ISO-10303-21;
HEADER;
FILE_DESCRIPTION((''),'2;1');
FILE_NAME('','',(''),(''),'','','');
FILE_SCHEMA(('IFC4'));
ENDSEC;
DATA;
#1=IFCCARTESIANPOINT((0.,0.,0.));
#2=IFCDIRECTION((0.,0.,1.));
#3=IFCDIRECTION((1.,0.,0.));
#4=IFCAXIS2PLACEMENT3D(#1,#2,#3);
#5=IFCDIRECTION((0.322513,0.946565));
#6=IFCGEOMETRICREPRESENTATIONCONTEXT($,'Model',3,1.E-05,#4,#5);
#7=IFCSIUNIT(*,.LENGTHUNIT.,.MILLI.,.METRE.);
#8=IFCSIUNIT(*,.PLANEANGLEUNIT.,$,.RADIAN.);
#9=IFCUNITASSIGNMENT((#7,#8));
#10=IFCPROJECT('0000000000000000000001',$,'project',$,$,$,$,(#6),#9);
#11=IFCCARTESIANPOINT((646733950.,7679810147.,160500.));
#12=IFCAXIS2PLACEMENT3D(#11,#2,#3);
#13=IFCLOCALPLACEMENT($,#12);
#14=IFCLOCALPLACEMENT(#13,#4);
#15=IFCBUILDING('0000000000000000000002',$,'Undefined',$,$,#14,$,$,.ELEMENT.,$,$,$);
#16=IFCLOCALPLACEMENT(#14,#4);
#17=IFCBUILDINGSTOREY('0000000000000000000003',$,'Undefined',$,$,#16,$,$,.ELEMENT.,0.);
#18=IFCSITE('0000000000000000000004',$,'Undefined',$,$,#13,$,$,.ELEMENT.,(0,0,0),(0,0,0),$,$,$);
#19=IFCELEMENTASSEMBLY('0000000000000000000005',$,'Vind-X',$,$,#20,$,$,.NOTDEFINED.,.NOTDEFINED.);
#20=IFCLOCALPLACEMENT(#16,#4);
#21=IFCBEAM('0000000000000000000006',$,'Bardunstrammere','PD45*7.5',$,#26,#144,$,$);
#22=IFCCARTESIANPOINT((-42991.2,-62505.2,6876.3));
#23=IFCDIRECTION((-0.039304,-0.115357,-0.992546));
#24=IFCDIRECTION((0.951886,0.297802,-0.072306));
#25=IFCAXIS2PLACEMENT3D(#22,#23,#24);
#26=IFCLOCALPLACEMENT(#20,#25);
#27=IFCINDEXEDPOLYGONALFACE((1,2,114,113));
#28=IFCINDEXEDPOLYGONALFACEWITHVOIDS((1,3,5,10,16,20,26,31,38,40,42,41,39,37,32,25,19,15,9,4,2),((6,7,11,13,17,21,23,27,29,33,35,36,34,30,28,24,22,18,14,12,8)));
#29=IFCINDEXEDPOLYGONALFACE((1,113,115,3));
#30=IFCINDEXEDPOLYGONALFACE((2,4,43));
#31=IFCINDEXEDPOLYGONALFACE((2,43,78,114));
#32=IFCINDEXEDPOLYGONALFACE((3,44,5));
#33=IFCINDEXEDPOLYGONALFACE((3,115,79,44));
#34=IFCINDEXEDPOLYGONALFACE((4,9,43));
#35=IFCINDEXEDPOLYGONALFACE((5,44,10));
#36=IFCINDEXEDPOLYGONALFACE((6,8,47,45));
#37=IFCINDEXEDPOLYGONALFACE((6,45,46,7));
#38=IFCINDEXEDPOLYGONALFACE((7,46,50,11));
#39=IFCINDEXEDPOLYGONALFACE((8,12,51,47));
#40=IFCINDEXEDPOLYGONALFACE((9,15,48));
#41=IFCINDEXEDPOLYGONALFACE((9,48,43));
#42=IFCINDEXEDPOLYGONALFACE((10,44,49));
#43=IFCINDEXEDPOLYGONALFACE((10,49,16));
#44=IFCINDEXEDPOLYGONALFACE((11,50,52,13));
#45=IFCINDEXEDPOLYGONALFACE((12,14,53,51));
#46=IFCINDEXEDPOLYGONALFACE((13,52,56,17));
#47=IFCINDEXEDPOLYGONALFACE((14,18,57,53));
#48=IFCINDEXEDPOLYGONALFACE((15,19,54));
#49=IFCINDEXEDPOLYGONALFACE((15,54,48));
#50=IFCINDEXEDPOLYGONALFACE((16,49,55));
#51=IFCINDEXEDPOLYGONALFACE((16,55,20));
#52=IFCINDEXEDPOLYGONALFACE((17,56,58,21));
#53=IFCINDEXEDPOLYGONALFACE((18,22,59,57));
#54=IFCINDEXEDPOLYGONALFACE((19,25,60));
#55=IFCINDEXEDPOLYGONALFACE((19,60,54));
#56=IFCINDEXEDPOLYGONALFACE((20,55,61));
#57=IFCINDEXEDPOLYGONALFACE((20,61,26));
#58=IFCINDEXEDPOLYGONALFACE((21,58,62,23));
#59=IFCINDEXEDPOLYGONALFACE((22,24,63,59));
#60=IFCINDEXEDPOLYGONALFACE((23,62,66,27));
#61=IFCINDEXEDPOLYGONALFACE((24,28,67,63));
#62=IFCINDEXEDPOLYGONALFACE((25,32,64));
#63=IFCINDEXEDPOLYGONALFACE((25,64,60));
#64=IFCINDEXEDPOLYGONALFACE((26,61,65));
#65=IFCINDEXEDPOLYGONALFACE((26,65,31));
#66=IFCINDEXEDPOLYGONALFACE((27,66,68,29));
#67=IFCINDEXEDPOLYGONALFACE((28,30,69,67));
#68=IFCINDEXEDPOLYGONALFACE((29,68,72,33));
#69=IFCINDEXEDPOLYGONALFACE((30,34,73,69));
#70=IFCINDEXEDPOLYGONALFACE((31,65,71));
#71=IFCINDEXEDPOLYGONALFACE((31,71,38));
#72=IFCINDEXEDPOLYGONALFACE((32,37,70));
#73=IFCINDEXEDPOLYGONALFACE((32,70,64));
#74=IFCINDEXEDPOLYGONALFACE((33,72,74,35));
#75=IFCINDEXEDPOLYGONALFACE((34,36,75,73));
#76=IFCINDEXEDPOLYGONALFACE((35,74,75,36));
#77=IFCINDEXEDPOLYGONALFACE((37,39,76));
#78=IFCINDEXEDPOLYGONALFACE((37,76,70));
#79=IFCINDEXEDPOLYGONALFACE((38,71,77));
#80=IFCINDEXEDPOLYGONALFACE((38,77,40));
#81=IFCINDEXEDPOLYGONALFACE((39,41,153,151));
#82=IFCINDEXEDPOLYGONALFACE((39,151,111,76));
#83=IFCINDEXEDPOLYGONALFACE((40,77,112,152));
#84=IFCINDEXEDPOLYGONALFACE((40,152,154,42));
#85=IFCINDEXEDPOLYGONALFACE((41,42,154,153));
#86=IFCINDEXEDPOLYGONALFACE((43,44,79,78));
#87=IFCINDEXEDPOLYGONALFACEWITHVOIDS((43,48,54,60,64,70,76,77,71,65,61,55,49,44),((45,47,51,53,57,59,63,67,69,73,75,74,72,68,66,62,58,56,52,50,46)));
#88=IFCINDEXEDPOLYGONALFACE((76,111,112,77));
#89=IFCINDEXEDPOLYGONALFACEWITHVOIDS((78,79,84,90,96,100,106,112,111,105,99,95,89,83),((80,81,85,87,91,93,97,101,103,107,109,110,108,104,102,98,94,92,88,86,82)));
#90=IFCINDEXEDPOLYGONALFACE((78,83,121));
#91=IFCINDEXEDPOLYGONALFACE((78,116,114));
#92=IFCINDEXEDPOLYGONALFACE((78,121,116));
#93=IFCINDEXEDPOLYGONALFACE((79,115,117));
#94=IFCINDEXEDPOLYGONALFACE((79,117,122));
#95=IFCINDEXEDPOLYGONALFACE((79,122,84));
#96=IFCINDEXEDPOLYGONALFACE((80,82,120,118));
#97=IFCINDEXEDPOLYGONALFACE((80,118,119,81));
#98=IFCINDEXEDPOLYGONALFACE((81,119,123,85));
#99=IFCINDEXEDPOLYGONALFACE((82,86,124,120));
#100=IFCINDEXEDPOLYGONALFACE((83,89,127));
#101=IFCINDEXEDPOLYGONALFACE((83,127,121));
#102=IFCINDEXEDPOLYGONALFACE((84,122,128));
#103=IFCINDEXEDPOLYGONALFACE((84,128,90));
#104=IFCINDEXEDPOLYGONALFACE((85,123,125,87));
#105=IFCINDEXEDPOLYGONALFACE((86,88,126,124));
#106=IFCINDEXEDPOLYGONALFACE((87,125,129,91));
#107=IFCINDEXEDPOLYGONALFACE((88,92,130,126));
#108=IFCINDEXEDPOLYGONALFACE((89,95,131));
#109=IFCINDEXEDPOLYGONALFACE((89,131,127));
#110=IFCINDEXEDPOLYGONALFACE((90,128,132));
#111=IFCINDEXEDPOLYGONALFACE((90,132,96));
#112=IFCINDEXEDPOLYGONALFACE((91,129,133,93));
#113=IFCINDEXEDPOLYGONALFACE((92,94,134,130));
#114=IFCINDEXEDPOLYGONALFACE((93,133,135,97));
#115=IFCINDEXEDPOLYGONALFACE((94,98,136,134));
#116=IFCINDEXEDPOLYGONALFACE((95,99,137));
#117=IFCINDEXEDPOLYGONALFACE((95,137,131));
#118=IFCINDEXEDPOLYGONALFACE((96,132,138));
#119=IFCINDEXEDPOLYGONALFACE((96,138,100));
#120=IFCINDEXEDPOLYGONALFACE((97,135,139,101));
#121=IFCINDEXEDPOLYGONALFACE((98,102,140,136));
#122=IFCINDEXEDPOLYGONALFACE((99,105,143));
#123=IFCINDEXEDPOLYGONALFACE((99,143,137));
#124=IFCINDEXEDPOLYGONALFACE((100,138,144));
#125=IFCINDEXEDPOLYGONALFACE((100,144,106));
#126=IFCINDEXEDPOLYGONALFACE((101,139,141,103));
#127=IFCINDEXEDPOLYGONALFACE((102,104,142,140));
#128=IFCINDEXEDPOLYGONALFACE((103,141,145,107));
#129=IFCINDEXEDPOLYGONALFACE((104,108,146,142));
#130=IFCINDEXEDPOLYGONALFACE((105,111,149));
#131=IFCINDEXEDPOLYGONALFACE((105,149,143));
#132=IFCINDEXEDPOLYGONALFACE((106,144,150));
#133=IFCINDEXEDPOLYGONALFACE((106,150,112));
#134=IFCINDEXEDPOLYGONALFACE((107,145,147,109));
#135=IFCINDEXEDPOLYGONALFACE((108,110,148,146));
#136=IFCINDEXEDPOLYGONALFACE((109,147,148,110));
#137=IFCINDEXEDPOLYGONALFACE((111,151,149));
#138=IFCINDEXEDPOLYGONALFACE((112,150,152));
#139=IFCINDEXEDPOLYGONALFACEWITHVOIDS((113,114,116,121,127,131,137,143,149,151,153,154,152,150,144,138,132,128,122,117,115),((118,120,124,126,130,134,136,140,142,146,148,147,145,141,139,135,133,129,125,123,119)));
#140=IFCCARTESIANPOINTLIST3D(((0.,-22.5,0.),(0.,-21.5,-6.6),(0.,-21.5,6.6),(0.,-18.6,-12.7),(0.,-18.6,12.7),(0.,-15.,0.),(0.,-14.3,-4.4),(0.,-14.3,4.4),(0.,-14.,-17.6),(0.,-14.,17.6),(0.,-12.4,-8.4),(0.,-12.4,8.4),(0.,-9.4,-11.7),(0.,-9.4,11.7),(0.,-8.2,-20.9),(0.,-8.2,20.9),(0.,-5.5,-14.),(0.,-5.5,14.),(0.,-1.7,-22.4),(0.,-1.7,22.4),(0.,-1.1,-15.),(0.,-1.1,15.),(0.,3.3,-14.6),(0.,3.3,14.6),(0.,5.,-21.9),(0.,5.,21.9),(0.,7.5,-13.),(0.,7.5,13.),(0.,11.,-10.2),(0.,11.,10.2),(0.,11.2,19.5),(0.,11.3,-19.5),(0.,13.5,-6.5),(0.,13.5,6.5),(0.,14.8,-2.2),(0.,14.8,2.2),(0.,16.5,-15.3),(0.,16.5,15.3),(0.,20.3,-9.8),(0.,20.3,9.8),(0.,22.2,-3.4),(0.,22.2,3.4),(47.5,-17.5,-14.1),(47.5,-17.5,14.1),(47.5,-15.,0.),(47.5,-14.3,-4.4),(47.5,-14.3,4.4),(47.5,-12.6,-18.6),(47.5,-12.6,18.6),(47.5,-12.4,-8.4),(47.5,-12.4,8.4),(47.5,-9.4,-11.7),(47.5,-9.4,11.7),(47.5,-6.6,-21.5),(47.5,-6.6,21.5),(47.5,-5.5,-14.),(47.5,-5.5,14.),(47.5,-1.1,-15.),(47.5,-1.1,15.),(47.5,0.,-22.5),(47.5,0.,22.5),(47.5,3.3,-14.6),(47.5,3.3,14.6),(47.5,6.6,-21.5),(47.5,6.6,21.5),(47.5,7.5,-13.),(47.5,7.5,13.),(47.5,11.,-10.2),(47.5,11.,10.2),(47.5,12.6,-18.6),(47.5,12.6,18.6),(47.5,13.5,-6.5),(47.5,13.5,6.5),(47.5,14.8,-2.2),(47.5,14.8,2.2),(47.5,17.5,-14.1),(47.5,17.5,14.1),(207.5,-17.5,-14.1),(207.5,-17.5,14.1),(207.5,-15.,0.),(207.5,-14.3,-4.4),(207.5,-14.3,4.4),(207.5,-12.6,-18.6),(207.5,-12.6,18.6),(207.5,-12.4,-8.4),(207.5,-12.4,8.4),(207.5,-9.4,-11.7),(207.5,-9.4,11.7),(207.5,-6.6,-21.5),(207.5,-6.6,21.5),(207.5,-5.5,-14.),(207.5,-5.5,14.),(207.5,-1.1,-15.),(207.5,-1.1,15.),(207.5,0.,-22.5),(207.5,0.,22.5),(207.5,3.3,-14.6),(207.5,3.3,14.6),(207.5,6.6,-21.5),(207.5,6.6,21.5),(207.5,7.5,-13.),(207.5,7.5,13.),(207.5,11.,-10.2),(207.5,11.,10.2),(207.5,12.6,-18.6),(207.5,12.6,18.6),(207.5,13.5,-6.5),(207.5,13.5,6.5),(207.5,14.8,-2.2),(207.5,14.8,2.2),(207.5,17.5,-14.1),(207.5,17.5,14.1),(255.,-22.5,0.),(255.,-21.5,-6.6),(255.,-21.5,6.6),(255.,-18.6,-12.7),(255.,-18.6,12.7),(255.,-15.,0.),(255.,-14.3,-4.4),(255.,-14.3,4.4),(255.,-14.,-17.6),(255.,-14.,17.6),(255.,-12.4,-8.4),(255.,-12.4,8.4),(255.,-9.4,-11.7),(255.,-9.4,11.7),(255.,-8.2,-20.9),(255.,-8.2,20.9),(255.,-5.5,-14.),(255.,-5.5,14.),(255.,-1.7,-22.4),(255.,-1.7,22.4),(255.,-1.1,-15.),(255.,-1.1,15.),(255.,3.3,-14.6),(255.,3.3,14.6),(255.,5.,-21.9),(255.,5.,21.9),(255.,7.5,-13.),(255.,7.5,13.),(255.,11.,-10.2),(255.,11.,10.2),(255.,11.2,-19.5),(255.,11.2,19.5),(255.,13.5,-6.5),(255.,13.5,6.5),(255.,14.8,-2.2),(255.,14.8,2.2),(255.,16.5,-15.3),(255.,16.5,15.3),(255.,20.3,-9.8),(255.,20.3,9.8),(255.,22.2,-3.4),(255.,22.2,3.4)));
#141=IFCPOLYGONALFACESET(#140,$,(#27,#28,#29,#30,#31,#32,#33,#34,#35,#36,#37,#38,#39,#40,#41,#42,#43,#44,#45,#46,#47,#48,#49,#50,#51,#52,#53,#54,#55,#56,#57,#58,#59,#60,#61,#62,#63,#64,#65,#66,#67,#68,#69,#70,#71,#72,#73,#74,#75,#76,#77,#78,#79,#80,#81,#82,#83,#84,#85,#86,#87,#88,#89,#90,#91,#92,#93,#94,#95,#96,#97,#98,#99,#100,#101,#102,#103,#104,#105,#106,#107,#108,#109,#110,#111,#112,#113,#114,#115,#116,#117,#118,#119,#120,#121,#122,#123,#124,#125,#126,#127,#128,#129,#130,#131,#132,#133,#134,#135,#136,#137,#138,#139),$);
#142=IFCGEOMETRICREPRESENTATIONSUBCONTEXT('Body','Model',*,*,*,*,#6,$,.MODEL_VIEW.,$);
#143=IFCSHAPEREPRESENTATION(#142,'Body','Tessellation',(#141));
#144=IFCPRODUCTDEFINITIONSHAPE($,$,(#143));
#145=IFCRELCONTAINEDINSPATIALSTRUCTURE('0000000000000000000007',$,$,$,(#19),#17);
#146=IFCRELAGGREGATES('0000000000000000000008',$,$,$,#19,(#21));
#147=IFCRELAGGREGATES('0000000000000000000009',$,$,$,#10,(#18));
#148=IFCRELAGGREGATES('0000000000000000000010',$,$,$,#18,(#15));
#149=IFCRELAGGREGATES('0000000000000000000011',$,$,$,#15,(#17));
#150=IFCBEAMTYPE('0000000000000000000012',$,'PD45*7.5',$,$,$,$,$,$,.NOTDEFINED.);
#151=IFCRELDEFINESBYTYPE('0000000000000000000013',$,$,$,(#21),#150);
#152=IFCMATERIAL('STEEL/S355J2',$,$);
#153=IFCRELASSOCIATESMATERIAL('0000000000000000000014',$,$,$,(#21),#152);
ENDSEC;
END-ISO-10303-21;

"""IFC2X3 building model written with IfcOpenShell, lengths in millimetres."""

from ifc_helpers import new_model, si_unit, direction, frame, origin_with_axes, origin_2d_with_axis, place, context, subcontext, project, spatial, rectangle, hollow_circle, extrude, boolean, material, type_object, element, aggregate, save


model = new_model("IFC2X3")

# Units and contexts
model_context = context("Model", 3, precision=1e-05, world=origin_with_axes(), true_north=direction((0.322513, 0.946565)))
body_context = subcontext(model_context, "Body", "Model", "MODEL_VIEW")
ifc_project = project(units=[si_unit("LENGTHUNIT", "METRE", prefix="MILLI"), si_unit("PLANEANGLEUNIT", "RADIAN")], contexts=[model_context])

# Site, building, storey
site_placement = place(None, frame((646733950.0, 7679810147.0, 160500.0), z_axis=(0.0, 0.0, 1.0), x_axis=(1.0, 0.0, 0.0)))
site = spatial("IfcSite", under=ifc_project, at=site_placement, Name="Undefined", CompositionType="ELEMENT", RefLatitude=(0, 0, 0), RefLongitude=(0, 0, 0))
building_placement = place(site_placement, origin_with_axes())
building = spatial("IfcBuilding", under=site, at=building_placement, Name="Undefined", CompositionType="ELEMENT")
storey_placement = place(building_placement, origin_with_axes())
storey = spatial("IfcBuildingStorey", under=building, at=storey_placement, Name="Undefined", CompositionType="ELEMENT", Elevation=0.0)

# Element assembly, beam
assembly_1_placement = place(storey_placement, origin_with_axes())
assembly_1 = element("IfcElementAssembly", 1, at=assembly_1_placement, inside=storey, Name="Vind-X", AssemblyPlace="NOTDEFINED", PredefinedType="NOTDEFINED")
ifc_material_1 = material(Name="STEEL/S355J2")
beam_type_1 = type_object("IfcBeamType", Name="PD45*7.5", PredefinedType="NOTDEFINED")
beam_1_placement = place(assembly_1_placement, frame((-42991.2, -62505.2, 6876.3), z_axis=(-0.039304, -0.115357, -0.992546), x_axis=(0.951886, 0.297802, -0.072306)))
beam_1 = element("IfcBeam", 2, at=beam_1_placement, type_object=beam_type_1, material=ifc_material_1, Name="Bardunstrammere", Description="PD45*7.5", context=body_context, shape_type="CSG", body=[
    boolean("DIFFERENCE", extrude(hollow_circle(Radius=22.5, WallThickness=7.5, at=origin_2d_with_axis()), frame((255.0, 0.0, 0.0), z_axis=(-1.0, 0.0, 0.0), x_axis=(0.0, -1.0, 0.0)), (0.0, 0.0, 1.0), 255.0), extrude(rectangle(XDim=35.0, YDim=90.0, at=origin_2d_with_axis()), frame((207.5, 0.0, 0.0), z_axis=(-1.0, 0.0, 0.0), x_axis=(0.0, -1.0, 0.0)), (0.0, 0.0, 1.0), 160.0)),
])

aggregate(assembly_1, [beam_1])

save(model, "model.ifc")
